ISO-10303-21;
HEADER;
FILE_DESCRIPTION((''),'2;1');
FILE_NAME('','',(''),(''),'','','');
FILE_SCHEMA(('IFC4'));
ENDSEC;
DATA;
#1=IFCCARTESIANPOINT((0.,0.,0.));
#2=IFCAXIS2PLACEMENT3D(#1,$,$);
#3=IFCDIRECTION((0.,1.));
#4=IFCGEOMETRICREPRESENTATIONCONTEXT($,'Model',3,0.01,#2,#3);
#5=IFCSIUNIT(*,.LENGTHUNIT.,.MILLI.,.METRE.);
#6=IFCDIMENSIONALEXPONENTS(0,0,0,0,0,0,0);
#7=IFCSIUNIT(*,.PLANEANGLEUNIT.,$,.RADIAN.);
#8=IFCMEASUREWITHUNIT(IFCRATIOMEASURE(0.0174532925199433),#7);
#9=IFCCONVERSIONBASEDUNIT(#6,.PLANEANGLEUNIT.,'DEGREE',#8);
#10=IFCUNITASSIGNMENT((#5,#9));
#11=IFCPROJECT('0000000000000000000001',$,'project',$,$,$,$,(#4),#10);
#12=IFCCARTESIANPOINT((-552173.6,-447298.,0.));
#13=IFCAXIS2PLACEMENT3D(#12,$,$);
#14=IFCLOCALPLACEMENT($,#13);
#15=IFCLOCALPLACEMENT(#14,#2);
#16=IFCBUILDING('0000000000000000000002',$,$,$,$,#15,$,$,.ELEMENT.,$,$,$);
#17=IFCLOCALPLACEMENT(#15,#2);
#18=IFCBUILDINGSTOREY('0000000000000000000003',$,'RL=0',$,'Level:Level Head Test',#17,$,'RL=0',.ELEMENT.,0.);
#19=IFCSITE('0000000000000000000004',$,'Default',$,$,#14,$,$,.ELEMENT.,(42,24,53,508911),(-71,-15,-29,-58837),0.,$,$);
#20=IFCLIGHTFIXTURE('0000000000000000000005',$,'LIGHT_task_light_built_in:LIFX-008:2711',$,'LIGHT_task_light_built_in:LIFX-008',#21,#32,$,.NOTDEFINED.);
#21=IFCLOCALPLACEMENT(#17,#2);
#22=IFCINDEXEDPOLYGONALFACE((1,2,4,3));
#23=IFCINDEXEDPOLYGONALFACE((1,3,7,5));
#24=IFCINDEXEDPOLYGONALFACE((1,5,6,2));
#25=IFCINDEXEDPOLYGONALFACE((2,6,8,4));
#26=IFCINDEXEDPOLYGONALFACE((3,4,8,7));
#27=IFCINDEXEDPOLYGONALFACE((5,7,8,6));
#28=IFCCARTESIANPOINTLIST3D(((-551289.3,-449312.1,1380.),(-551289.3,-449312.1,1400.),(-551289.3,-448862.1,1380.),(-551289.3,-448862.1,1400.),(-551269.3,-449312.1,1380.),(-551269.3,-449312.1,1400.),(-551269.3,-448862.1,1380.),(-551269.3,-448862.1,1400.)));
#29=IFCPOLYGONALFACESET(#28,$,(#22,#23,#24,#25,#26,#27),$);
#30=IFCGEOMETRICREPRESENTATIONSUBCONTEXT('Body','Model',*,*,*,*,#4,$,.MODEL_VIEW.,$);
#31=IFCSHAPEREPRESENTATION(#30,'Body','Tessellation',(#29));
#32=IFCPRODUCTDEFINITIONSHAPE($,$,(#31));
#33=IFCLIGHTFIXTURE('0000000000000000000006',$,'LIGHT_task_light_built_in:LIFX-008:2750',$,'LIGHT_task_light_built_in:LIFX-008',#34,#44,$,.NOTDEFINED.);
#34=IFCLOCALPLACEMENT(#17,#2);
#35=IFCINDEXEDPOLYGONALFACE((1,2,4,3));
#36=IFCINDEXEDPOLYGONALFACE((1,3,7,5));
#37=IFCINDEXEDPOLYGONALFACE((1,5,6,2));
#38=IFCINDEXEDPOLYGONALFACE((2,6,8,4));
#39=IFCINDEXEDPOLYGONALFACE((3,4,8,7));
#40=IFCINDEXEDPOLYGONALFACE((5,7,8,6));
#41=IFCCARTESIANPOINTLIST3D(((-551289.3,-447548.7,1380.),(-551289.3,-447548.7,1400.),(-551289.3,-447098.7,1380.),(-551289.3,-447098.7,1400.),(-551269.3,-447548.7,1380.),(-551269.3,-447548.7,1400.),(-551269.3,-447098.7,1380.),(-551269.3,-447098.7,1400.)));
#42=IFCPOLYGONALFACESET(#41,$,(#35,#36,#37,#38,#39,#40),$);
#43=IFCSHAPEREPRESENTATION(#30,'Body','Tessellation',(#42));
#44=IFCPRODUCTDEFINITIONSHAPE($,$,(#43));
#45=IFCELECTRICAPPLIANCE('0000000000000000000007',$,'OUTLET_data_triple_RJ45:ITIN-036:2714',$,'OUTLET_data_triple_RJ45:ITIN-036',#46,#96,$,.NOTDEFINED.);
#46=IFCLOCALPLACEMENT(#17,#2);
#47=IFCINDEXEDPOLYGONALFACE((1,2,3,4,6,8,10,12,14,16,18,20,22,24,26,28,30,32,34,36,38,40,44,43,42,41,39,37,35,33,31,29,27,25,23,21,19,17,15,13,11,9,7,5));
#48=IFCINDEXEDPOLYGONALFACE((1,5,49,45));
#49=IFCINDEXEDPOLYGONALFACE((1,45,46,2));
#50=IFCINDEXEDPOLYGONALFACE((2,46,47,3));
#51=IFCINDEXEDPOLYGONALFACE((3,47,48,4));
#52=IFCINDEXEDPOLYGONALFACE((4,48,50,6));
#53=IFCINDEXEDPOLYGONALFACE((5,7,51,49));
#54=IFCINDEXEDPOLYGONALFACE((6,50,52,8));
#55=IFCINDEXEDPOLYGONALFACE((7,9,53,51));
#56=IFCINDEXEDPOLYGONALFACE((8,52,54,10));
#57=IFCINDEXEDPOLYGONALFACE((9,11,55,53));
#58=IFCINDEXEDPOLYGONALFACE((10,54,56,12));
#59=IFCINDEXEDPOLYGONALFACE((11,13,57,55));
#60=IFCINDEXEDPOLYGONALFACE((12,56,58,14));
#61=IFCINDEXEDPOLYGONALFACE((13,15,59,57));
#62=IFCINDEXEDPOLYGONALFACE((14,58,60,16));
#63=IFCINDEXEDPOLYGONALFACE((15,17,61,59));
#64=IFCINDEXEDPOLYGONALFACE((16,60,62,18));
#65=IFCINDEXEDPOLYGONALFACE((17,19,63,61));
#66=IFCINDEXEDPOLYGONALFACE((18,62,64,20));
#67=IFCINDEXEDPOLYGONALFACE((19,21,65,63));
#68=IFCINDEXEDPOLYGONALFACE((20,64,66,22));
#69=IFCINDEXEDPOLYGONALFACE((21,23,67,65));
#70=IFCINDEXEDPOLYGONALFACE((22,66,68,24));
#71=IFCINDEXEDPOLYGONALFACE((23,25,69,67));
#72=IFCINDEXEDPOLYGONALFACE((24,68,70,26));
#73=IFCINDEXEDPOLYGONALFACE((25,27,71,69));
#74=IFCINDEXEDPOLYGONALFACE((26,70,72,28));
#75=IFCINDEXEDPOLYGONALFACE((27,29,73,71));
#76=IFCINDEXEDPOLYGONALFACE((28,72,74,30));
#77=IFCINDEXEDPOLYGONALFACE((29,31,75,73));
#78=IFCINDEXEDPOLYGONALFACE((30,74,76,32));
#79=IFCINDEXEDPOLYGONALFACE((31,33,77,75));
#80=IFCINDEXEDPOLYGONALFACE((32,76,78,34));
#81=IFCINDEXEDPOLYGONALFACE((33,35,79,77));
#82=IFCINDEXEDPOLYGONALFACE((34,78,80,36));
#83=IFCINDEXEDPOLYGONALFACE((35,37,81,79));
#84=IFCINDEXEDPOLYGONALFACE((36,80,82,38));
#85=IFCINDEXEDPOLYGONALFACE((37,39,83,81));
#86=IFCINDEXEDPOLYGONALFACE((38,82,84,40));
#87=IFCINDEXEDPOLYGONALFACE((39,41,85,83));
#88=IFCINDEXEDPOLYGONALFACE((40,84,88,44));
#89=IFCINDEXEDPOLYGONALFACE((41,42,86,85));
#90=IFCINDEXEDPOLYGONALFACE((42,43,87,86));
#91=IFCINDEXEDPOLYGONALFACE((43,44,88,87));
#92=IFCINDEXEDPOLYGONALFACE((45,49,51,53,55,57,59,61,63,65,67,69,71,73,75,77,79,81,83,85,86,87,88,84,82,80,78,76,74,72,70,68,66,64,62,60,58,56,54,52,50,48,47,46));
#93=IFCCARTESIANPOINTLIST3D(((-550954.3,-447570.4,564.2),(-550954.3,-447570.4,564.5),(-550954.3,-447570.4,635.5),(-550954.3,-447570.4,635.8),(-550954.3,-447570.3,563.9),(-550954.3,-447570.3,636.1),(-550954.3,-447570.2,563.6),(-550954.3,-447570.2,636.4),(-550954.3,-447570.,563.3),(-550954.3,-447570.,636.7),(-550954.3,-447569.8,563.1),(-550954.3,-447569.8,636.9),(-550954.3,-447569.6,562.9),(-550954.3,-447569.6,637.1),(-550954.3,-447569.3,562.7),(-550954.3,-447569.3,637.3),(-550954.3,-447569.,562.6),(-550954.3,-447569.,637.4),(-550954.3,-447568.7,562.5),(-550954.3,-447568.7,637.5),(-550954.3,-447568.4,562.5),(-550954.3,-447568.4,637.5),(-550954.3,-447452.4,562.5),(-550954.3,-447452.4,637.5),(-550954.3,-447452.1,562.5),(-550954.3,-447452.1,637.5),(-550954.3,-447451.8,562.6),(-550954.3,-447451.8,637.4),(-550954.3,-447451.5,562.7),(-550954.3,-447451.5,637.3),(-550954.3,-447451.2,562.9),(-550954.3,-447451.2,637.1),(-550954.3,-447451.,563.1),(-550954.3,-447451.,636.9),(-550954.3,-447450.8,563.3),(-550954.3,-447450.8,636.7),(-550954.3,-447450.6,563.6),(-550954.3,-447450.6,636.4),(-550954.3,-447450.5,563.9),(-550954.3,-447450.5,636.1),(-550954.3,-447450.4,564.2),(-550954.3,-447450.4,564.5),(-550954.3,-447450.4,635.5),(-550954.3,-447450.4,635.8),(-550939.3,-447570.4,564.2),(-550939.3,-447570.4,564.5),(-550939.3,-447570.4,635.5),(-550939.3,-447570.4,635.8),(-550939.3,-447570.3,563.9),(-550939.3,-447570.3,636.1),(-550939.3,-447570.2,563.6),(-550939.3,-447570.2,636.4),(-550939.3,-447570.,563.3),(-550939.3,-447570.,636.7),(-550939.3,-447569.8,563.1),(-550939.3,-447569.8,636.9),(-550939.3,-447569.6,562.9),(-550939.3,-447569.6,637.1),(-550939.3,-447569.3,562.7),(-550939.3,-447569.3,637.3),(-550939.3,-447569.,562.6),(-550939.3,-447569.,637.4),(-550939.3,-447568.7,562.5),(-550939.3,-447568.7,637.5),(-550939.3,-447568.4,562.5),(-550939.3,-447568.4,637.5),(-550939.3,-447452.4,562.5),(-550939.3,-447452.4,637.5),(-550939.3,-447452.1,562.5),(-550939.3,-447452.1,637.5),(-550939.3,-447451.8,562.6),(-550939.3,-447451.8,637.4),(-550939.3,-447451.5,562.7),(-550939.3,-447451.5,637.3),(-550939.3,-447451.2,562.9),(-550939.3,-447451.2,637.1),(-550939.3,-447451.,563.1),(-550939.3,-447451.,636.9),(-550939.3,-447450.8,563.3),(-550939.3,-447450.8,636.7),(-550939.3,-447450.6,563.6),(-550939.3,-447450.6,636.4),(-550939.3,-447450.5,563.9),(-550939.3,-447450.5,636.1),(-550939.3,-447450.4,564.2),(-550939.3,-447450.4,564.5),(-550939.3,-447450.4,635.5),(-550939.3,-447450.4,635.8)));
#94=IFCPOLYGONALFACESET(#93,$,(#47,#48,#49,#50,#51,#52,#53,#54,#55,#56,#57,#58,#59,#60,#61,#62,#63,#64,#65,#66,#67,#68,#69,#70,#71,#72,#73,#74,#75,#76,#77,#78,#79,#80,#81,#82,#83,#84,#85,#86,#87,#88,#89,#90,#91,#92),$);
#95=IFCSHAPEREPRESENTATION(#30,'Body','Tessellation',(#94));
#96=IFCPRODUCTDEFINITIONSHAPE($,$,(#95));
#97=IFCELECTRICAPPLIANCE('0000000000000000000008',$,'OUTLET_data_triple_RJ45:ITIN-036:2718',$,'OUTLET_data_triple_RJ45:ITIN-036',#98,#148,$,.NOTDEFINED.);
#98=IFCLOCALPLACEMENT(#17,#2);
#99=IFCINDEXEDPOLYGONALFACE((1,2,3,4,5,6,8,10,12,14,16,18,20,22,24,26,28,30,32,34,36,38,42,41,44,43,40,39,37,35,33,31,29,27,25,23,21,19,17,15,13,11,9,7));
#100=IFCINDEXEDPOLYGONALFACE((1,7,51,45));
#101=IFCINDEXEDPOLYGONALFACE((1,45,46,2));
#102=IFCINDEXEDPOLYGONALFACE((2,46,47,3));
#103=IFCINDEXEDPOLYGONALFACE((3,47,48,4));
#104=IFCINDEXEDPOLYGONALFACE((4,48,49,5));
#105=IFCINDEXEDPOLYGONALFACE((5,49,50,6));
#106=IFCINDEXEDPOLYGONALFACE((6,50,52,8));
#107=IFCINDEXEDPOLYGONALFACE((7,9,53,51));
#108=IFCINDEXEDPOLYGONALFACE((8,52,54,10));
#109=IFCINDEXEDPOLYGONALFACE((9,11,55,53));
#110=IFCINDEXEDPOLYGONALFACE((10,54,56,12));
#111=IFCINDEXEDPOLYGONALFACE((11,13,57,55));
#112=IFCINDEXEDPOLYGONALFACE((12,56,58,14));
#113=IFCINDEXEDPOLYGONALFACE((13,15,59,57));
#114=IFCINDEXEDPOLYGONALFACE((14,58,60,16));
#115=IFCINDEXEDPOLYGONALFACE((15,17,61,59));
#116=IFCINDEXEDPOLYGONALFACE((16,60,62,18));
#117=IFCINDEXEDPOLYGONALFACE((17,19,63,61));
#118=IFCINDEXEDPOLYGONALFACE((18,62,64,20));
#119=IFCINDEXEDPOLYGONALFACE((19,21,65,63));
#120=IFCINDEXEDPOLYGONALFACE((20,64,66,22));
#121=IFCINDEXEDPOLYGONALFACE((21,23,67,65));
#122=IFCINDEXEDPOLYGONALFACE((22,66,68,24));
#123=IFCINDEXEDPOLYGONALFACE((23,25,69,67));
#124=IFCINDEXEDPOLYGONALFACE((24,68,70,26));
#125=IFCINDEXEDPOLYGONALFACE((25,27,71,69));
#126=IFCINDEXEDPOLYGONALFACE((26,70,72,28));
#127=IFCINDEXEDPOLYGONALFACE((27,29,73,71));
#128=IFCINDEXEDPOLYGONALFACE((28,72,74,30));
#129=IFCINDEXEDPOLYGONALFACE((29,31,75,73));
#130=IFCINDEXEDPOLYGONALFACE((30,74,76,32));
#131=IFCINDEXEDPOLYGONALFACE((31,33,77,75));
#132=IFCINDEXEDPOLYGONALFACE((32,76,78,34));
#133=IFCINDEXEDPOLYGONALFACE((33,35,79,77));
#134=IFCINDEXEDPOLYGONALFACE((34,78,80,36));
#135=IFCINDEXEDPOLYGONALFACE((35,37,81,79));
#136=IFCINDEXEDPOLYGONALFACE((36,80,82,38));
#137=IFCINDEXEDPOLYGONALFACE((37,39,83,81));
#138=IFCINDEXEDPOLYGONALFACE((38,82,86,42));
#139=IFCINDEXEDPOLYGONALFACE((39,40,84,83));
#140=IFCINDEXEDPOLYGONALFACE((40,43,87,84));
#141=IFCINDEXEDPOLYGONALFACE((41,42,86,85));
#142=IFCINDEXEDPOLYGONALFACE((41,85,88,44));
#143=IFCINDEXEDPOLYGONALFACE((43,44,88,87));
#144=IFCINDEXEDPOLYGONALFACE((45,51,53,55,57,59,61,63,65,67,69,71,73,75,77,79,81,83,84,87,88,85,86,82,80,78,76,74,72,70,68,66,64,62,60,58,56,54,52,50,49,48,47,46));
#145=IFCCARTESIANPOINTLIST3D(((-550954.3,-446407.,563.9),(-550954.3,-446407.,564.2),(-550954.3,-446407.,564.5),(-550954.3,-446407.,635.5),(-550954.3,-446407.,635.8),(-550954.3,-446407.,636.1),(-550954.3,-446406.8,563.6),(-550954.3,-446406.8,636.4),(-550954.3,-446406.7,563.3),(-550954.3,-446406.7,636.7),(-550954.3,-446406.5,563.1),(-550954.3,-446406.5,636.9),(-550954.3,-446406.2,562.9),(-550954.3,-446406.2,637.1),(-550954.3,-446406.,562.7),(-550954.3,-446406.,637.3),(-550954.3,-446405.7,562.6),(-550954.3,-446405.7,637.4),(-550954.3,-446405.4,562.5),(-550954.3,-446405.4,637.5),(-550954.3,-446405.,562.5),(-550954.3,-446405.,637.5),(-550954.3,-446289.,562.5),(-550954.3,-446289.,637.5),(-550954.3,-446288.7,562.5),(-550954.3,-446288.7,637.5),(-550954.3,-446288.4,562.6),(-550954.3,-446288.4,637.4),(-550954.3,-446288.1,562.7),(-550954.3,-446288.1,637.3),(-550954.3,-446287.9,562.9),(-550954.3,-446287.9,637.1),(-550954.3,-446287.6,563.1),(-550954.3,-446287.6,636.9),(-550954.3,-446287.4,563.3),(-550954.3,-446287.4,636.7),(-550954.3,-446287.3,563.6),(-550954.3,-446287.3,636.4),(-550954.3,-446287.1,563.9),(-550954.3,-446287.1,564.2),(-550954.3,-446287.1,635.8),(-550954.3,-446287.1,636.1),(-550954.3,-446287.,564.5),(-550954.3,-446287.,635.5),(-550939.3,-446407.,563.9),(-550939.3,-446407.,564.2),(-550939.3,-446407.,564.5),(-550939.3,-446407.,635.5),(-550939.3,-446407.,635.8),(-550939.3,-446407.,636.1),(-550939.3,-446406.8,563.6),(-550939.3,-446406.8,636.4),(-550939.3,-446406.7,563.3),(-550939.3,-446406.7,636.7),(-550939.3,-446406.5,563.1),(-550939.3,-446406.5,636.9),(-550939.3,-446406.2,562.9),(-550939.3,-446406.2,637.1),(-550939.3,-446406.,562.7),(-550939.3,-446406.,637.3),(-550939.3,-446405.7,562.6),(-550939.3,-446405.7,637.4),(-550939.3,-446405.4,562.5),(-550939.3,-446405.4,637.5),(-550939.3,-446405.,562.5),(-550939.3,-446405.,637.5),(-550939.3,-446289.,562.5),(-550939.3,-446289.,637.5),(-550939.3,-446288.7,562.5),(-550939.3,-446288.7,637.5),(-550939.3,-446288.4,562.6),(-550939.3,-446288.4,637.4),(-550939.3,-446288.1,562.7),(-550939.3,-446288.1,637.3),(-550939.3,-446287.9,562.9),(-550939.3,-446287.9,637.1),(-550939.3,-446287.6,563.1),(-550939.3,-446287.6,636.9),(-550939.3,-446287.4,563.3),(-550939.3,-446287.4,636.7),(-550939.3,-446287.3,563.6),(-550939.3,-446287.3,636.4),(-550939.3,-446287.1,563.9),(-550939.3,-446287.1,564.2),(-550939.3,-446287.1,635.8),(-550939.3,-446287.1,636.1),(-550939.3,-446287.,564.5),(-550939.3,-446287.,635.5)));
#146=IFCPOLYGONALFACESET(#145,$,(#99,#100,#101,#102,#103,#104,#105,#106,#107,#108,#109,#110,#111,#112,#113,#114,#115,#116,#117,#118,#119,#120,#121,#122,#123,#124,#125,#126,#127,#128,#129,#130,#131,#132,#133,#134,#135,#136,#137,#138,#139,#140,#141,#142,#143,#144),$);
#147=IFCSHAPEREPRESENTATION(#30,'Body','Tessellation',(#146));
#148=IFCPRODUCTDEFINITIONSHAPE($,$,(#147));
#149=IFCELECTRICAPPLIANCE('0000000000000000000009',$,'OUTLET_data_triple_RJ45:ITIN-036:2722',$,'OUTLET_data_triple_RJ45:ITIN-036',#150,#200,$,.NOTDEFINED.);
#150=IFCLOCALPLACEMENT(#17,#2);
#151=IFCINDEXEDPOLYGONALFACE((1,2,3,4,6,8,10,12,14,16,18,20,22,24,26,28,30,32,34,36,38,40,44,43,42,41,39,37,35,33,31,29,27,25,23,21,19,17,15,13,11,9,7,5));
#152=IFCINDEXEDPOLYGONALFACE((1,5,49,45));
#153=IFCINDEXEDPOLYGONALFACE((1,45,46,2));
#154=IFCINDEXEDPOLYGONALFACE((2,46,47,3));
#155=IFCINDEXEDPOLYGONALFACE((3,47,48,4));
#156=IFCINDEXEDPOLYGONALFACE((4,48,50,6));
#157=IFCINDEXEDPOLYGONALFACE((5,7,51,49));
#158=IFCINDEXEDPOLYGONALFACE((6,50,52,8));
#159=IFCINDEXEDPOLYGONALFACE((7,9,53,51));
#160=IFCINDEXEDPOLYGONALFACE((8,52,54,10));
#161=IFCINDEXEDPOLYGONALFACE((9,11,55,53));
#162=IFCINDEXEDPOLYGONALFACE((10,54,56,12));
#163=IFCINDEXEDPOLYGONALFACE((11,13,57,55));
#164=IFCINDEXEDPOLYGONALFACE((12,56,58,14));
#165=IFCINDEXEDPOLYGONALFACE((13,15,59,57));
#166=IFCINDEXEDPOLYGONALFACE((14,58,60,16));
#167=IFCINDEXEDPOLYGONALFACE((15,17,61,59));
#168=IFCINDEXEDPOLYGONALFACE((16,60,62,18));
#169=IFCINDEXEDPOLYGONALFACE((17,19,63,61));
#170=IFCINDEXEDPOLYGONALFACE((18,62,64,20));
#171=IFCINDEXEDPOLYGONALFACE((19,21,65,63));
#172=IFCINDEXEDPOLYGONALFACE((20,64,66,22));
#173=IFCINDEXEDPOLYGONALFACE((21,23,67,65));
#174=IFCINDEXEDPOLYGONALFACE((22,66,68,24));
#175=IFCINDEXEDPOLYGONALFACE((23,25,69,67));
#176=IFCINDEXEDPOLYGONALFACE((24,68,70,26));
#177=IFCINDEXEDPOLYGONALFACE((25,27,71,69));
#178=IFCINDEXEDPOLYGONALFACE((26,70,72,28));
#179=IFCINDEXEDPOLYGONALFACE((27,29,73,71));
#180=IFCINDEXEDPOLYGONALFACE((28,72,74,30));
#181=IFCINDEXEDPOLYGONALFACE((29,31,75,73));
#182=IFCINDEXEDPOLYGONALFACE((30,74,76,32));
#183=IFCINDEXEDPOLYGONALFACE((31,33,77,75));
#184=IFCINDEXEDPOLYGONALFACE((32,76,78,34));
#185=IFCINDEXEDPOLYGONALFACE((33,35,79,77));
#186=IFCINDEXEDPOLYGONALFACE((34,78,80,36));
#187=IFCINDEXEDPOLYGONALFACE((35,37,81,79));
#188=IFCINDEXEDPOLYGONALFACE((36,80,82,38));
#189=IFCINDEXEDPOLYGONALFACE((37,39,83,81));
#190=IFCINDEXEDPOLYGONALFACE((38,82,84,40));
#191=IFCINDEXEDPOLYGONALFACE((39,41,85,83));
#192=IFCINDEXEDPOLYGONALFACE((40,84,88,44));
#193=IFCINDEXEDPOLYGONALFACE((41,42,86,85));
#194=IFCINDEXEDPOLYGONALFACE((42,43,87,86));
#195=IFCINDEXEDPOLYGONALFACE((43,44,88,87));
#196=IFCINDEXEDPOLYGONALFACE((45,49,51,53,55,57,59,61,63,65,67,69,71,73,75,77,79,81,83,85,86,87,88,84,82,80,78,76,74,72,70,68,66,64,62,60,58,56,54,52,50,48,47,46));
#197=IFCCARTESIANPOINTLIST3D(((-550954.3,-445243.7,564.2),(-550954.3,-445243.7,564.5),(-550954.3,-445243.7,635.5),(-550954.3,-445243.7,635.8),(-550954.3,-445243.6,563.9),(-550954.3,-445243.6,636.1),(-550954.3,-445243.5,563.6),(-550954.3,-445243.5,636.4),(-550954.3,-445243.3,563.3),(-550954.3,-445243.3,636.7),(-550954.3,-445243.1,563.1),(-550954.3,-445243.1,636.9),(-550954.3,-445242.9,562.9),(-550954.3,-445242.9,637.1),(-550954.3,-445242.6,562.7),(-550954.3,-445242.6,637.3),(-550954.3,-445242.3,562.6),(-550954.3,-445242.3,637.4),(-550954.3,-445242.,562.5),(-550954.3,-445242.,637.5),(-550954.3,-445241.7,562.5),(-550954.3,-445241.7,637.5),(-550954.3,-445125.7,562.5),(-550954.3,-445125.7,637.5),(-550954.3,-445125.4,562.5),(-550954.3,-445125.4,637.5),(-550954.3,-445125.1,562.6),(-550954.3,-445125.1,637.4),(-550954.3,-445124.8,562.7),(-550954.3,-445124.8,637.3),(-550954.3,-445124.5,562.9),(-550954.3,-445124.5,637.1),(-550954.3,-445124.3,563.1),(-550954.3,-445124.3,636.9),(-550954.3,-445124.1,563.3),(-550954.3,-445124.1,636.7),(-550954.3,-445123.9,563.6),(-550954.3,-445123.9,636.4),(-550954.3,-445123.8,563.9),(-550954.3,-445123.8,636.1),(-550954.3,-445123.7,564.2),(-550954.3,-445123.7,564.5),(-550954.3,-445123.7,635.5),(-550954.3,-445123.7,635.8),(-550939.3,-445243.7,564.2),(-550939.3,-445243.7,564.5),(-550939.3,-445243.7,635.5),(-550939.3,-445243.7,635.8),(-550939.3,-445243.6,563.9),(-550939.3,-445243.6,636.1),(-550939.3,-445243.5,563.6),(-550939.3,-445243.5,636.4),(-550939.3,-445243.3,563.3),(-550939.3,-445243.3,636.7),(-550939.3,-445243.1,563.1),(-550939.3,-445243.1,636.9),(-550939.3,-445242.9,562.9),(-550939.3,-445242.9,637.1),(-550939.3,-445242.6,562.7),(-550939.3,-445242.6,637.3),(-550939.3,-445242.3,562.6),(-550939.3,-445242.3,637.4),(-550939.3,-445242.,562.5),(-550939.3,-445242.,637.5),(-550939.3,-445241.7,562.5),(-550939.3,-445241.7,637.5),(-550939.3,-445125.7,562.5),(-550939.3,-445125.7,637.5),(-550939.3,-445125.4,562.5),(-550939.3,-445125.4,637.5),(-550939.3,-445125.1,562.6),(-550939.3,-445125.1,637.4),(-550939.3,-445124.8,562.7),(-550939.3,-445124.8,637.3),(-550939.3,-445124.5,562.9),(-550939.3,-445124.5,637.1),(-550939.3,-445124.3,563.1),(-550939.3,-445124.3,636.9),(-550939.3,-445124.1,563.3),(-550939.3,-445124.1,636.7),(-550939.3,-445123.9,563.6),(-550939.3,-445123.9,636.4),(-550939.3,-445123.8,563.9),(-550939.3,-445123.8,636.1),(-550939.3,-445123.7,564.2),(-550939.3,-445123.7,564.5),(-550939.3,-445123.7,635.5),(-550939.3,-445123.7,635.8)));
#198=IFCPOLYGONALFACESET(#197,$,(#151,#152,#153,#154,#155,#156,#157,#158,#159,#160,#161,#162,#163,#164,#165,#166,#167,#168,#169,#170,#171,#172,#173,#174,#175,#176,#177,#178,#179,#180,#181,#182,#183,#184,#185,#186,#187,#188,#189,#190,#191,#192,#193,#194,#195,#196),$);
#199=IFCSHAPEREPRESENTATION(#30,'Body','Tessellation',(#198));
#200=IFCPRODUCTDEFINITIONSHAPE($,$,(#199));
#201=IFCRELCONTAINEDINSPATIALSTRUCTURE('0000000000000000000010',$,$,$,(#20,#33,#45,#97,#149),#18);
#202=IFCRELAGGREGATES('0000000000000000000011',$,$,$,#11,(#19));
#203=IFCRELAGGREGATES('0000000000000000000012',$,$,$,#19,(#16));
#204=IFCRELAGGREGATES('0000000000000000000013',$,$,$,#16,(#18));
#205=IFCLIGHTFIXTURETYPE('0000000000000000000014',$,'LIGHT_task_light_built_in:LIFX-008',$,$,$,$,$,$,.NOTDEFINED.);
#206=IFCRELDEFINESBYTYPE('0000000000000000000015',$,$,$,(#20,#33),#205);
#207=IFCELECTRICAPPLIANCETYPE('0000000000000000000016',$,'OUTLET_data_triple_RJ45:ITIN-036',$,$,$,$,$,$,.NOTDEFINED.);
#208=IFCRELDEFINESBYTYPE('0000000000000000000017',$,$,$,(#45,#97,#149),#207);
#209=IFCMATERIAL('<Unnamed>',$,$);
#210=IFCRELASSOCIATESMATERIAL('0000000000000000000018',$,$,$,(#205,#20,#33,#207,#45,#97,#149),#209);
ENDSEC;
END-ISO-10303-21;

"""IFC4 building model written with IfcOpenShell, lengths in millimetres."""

from ifc_helpers import new_model, entity, si_unit, converted_unit, direction, frame, origin, place, context, subcontext, project, spatial, indexed_curve, outline, extrude, source, transform, mapped, material, type_object, type_shapes, element, save


model = new_model("IFC4")

# Units and contexts
model_context = context("Model", 3, precision=0.01, world=origin(), true_north=direction((0.0, 1.0)))
body_context = subcontext(model_context, "Body", "Model", "MODEL_VIEW")
ifc_project = project(units=[si_unit("LENGTHUNIT", "METRE", prefix="MILLI"), converted_unit("PLANEANGLEUNIT", "DEGREE", entity("IfcRatioMeasure", 0.0174532925199433), si_unit("PLANEANGLEUNIT", "RADIAN"), dimensions=[0, 0, 0, 0, 0, 0, 0])], contexts=[model_context])

# Site, building, storey
site_placement = place(None, frame((-552173.6, -447298.0, 0.0)))
site = spatial("IfcSite", under=ifc_project, at=site_placement, Name="Default", CompositionType="ELEMENT", RefLatitude=(42, 24, 53, 508911), RefLongitude=(-71, -15, -29, -58837), RefElevation=0.0)
building_placement = place(site_placement, origin())
building = spatial("IfcBuilding", under=site, at=building_placement, CompositionType="ELEMENT")
storey_placement = place(building_placement, origin())
storey = spatial("IfcBuildingStorey", under=building, at=storey_placement, Name="RL=0", ObjectType="Level:Level Head Test", LongName="RL=0", CompositionType="ELEMENT", Elevation=0.0)

# Shared definitions
ifc_material_1 = material(Name="<Unnamed>")

# Light fixtures
light_fixture_type = type_object("IfcLightFixtureType", Name="LIGHT_task_light_built_in:LIFX-008", PredefinedType="NOTDEFINED", material=ifc_material_1)
shared_shape_1 = source(origin(), body_context, "Body", "SweptSolid", [
    extrude(outline(indexed_curve([(-225.0, -10.0), (225.0, -10.0), (225.0, 10.0), (-225.0, 10.0), (-225.0, -10.0)], self_intersect=False)), frame((0.0, 0.0, 0.0), z_axis=(0.0, 0.0, 1.0), x_axis=(-1.0, 0.0, 0.0)), (0.0, 0.0, 1.0), 20.0),
])
type_shapes(light_fixture_type, [shared_shape_1])
for number, where, z_axis, x_axis, name in (
    (1, (-551279.3, -449087.1, 1380.0), (0.0, 0.0, 1.0), (0.0, 1.0, 0.0), "LIGHT_task_light_built_in:LIFX-008:2711"),
    (2, (-551279.3, -447323.7, 1380.0), (0.0, 0.0, 1.0), (0.0, 1.0, 0.0), "LIGHT_task_light_built_in:LIFX-008:2750"),
):
    element("IfcLightFixture", number, at=place(storey_placement, frame(where, z_axis=z_axis, x_axis=x_axis)), inside=storey, type_object=light_fixture_type, material=ifc_material_1, Name=name, ObjectType="LIGHT_task_light_built_in:LIFX-008", PredefinedType="NOTDEFINED", context=body_context, shape_type="MappedRepresentation", body=[
        mapped(shared_shape_1, transform((0.0, 0.0, 0.0), scale=1.0)),
    ])

# Electric appliances
electric_appliance_type_1 = type_object("IfcElectricApplianceType", Name="OUTLET_data_triple_RJ45:ITIN-036", PredefinedType="NOTDEFINED", material=ifc_material_1)
shared_shape_2 = source(origin(), body_context, "Body", "SweptSolid", [
    extrude(outline(indexed_curve([(-35.5, -60.0), (35.5, -60.0), (35.8, -60.0), (36.1, -59.9), (36.4, -59.8), (36.7, -59.6), (36.9, -59.4), (37.1, -59.2), (37.3, -58.9), (37.4, -58.6), (37.5, -58.3), (37.5, -58.0), (37.5, 58.0), (37.5, 58.3), (37.4, 58.6), (37.3, 58.9), (37.1, 59.2), (36.9, 59.4), (36.7, 59.6), (36.4, 59.8), (36.1, 59.9), (35.8, 60.0), (35.5, 60.0), (-35.5, 60.0), (-35.8, 60.0), (-36.1, 59.9), (-36.4, 59.8), (-36.7, 59.6), (-36.9, 59.4), (-37.1, 59.2), (-37.3, 58.9), (-37.4, 58.6), (-37.5, 58.3), (-37.5, 58.0), (-37.5, -58.0), (-37.5, -58.3), (-37.4, -58.6), (-37.3, -58.9), (-37.1, -59.2), (-36.9, -59.4), (-36.7, -59.6), (-36.4, -59.8), (-36.1, -59.9), (-35.8, -60.0), (-35.5, -60.0)], self_intersect=False)), frame((0.0, -15.0, 0.0), z_axis=(0.0, 1.0, 0.0), x_axis=(0.0, 0.0, 1.0)), (0.0, 0.0, 1.0), 15.0),
])
type_shapes(electric_appliance_type_1, [shared_shape_2])
for number, where, z_axis, x_axis, name in (
    (3, (-550939.3, -447510.4, 600.0), (0.0, 0.0, 1.0), (0.0, -1.0, 0.0), "OUTLET_data_triple_RJ45:ITIN-036:2714"),
    (4, (-550939.3, -446347.0, 600.0), (0.0, 0.0, 1.0), (0.0, -1.0, 0.0), "OUTLET_data_triple_RJ45:ITIN-036:2718"),
    (5, (-550939.3, -445183.7, 600.0), (0.0, 0.0, 1.0), (0.0, -1.0, 0.0), "OUTLET_data_triple_RJ45:ITIN-036:2722"),
):
    element("IfcElectricAppliance", number, at=place(storey_placement, frame(where, z_axis=z_axis, x_axis=x_axis)), inside=storey, type_object=electric_appliance_type_1, material=ifc_material_1, Name=name, ObjectType="OUTLET_data_triple_RJ45:ITIN-036", PredefinedType="NOTDEFINED", context=body_context, shape_type="MappedRepresentation", body=[
        mapped(shared_shape_2, transform((0.0, 0.0, 0.0), scale=1.0)),
    ])

save(model, "model.ifc")
